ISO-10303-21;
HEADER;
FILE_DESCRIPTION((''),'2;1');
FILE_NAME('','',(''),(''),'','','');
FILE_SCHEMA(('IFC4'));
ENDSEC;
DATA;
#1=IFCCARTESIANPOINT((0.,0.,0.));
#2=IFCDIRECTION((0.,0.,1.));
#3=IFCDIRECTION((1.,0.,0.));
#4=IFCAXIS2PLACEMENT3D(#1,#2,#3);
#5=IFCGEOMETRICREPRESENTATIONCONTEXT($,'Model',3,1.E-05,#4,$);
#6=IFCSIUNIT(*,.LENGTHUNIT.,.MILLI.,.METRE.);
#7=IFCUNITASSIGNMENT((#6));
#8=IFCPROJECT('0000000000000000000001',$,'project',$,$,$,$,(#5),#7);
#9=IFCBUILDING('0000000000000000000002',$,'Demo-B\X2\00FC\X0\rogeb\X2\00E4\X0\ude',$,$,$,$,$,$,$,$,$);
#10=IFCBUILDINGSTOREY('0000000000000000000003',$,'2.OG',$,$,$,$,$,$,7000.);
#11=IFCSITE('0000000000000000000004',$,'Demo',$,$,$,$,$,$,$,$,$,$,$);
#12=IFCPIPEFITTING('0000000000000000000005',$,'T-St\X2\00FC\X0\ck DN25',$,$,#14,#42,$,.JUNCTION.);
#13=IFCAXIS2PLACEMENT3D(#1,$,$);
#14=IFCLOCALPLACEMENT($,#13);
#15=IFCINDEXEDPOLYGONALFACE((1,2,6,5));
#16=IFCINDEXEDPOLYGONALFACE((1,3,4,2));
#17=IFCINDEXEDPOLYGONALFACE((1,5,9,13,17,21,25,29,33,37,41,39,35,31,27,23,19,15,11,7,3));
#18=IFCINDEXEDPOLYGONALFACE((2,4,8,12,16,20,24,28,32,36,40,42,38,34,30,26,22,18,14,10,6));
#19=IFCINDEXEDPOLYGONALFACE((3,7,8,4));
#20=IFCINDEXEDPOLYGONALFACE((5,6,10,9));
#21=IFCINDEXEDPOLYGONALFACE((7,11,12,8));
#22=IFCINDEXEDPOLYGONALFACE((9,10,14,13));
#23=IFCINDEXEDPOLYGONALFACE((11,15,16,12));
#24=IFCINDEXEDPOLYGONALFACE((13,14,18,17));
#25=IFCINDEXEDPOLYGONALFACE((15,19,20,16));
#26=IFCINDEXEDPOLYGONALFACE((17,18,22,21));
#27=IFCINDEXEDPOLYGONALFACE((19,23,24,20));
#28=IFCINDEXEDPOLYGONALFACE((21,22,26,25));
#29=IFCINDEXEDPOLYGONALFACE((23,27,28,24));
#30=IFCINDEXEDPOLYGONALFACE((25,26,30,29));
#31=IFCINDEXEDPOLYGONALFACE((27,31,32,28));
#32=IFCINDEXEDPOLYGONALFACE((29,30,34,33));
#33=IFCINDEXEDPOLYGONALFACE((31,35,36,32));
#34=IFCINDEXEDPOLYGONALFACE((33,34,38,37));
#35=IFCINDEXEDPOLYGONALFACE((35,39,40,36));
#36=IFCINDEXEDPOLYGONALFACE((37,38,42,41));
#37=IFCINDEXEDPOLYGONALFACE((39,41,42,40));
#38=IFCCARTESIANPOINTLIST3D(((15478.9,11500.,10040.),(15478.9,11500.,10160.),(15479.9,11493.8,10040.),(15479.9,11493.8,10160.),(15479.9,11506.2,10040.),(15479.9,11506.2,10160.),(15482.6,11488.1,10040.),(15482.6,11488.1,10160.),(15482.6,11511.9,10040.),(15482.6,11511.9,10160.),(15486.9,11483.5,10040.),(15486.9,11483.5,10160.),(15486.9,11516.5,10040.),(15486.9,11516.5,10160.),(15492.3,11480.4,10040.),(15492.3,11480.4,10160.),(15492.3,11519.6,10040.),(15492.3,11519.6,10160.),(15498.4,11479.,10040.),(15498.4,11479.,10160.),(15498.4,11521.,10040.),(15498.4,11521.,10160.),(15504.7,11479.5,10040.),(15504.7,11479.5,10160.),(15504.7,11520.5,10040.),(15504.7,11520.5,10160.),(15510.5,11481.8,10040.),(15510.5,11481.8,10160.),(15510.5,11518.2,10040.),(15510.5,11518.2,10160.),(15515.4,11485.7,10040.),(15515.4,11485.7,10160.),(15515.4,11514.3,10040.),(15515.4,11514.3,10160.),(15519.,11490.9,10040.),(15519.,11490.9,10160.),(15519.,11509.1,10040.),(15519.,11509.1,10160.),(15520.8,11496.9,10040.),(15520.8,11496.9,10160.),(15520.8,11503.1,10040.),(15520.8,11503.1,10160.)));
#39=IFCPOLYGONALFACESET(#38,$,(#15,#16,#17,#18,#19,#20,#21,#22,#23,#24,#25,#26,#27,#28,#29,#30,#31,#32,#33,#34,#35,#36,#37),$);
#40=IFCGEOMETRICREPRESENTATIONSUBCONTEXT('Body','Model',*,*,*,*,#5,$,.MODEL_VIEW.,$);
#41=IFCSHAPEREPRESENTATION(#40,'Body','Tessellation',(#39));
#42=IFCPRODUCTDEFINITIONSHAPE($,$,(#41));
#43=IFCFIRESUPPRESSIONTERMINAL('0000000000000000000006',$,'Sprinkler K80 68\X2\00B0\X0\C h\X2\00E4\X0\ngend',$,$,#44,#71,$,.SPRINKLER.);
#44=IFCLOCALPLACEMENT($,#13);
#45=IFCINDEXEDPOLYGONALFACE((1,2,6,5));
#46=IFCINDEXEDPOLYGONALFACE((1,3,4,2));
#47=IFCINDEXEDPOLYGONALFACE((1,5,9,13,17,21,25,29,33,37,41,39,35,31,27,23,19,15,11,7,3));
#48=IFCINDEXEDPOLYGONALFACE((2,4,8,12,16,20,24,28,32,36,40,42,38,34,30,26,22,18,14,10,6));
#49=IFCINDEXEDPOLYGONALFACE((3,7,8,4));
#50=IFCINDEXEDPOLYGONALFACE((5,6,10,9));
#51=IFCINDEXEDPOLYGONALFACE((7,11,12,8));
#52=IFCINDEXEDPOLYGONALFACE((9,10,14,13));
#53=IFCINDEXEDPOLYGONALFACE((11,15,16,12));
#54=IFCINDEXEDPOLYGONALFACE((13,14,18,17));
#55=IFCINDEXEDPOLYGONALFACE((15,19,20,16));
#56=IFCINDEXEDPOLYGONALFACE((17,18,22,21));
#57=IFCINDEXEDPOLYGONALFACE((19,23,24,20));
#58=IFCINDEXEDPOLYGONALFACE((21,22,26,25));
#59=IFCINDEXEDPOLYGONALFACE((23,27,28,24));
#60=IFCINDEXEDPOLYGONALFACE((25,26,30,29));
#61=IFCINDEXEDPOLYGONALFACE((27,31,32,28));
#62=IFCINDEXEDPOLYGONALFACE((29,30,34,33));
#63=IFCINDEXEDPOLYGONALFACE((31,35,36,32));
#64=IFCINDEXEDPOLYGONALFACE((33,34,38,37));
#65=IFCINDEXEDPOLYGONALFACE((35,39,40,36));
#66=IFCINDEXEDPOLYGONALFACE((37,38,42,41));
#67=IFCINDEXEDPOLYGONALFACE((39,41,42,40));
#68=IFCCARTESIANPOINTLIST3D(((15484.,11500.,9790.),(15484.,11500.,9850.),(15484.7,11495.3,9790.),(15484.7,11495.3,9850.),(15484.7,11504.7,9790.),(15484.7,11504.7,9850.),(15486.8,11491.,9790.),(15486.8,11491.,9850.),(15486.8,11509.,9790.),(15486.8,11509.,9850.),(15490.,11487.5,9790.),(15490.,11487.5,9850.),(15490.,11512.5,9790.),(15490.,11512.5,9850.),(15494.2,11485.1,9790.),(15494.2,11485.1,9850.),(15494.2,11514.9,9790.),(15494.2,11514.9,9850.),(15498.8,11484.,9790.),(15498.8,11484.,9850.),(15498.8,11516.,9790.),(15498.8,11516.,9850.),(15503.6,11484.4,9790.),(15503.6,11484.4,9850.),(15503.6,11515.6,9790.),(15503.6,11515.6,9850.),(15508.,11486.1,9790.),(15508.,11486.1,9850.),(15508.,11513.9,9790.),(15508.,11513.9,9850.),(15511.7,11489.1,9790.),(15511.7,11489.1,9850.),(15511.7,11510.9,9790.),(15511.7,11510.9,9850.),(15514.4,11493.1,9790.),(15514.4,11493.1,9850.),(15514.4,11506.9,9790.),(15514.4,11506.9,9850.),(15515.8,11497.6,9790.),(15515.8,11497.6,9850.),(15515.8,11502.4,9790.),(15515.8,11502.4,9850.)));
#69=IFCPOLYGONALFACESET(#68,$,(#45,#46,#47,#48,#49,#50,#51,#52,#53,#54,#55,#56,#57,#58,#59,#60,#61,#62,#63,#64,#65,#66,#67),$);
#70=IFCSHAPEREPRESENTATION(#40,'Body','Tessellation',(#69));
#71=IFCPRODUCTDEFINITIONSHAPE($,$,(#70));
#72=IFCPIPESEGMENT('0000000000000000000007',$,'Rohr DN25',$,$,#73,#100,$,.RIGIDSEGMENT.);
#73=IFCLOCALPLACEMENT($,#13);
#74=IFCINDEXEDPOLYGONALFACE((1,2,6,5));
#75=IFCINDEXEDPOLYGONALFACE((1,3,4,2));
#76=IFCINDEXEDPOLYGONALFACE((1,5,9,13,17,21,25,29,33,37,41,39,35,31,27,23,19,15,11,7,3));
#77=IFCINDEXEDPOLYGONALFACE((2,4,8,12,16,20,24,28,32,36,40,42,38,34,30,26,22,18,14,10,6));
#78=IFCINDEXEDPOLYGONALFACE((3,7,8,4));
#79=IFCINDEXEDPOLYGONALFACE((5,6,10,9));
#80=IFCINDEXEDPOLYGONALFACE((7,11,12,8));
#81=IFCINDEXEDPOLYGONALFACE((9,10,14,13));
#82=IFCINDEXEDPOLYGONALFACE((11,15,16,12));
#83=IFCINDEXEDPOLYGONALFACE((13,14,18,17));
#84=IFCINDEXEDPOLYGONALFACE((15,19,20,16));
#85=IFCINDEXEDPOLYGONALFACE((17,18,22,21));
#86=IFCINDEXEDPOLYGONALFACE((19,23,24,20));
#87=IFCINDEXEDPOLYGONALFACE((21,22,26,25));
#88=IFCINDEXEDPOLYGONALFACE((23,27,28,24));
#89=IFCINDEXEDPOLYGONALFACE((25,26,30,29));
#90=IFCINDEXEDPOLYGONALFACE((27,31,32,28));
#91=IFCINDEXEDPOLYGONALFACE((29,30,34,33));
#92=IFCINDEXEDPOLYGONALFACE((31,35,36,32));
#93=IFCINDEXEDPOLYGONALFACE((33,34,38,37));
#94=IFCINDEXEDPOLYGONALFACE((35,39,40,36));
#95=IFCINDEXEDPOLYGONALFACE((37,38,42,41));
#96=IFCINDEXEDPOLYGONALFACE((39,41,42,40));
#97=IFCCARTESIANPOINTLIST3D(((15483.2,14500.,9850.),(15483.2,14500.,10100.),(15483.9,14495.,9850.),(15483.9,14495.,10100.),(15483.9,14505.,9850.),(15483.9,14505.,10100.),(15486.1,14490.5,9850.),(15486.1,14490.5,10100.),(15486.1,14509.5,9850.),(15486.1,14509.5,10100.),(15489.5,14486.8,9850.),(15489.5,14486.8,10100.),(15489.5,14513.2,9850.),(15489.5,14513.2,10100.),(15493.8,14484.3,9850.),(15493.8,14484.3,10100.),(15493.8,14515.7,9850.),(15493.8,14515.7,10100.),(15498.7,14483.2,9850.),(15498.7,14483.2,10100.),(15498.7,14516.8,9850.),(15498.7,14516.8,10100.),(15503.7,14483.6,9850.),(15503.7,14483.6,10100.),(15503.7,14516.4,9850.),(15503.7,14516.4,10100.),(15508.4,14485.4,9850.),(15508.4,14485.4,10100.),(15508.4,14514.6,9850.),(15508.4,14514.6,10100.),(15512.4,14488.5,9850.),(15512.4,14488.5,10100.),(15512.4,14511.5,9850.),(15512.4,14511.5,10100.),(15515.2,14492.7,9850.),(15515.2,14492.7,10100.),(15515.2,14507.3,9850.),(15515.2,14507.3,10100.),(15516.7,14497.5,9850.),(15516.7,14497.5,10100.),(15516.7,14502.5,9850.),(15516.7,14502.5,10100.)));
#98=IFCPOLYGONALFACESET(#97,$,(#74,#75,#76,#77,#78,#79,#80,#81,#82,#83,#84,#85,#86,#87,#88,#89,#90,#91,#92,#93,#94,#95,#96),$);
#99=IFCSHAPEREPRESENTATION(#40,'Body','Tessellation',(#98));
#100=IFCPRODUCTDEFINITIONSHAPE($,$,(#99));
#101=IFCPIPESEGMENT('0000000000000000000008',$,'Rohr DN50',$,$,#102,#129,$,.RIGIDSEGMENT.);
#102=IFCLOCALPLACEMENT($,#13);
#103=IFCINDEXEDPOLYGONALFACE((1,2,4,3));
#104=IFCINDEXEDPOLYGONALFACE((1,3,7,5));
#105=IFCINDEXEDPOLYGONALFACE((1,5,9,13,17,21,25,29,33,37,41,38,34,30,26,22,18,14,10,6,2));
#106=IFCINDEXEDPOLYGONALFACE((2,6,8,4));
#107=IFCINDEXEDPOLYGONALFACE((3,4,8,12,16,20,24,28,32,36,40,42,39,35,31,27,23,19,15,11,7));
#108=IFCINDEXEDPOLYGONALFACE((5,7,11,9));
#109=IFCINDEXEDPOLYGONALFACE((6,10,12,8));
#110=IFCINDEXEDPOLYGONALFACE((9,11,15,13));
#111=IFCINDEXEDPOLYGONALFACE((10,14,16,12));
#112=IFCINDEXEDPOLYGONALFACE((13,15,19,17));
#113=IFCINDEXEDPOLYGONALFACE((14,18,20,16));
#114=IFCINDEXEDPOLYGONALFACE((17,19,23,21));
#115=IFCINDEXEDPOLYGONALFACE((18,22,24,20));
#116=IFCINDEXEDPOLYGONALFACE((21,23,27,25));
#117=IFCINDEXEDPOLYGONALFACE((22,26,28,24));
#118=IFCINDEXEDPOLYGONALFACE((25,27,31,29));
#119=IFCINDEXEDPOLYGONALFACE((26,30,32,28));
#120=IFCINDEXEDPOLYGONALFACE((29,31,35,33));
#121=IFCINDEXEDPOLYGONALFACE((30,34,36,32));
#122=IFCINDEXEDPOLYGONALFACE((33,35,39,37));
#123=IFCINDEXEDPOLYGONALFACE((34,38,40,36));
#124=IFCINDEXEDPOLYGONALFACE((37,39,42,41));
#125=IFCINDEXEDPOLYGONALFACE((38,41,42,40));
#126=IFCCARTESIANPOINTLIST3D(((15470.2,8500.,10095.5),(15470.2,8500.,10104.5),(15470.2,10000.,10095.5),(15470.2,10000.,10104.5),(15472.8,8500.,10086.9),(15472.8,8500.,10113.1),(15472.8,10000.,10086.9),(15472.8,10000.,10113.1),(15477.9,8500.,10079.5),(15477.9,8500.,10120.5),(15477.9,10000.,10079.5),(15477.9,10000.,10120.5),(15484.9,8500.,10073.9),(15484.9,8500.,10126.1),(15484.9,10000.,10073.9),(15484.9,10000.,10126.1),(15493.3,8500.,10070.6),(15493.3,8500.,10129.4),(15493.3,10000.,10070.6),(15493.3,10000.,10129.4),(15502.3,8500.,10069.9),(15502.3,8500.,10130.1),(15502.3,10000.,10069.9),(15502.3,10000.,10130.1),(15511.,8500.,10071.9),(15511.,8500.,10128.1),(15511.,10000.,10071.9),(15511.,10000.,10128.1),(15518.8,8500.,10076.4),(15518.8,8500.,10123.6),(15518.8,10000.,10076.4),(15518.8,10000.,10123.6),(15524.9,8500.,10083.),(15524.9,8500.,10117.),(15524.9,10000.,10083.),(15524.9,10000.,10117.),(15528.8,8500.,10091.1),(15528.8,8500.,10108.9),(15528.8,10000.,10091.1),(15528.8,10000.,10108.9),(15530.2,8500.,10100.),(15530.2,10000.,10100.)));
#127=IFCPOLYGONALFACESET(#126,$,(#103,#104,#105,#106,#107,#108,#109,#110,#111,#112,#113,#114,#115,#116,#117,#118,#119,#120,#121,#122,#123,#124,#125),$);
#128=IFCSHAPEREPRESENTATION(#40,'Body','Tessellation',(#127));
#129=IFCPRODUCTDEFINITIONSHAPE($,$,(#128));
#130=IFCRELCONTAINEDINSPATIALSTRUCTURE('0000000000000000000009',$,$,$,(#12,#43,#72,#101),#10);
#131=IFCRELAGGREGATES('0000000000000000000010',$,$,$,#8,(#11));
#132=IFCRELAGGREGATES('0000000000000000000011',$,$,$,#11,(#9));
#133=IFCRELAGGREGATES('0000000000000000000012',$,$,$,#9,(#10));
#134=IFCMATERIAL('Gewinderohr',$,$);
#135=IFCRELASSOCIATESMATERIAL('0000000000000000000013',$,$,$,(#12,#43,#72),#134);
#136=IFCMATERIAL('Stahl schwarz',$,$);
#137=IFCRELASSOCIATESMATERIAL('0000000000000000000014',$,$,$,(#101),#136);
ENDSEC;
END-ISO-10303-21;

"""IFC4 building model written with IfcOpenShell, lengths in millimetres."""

from ifc_helpers import new_model, si_unit, frame, origin_with_axes, place, context, subcontext, project, spatial, circle, extrude, material, element, save


model = new_model("IFC4")

# Units and contexts
model_context = context("Model", 3, precision=1e-05, world=origin_with_axes())
body_context = subcontext(model_context, "Body", "Model", "MODEL_VIEW")
ifc_project = project(units=[si_unit("LENGTHUNIT", "METRE", prefix="MILLI")], contexts=[model_context])

# Site, building, storey
site = spatial("IfcSite", under=ifc_project, Name="Demo")
building = spatial("IfcBuilding", under=site, Name="Demo-Bürogebäude")
storey = spatial("IfcBuildingStorey", under=building, Name="2.OG", Elevation=7000.0)

# Shared definitions
ifc_material_1 = material(Name="Stahl schwarz")

# Shared definitions
ifc_material_2 = material(Name="Gewinderohr")

# Pipe fitting
pipe_fitting_1_placement = place(None, frame((15500.0, 11500.0, 10160.0), z_axis=(0.0, 0.0, -1.0), x_axis=(-1.0, 0.0, 0.0)))
element("IfcPipeFitting", 1, at=pipe_fitting_1_placement, inside=storey, material=ifc_material_2, Name="T-Stück DN25", PredefinedType="JUNCTION", context=body_context, shape_type="SweptSolid", body=[
    extrude(circle(Radius=21.1), origin_with_axes(), (0.0, 0.0, 1.0), 120.0),
])

# Fire suppression terminal
fire_suppression_terminal_1_placement = place(None, frame((15500.0, 11500.0, 9850.0), z_axis=(0.0, 0.0, -1.0), x_axis=(-1.0, 0.0, 0.0)))
element("IfcFireSuppressionTerminal", 2, at=fire_suppression_terminal_1_placement, inside=storey, material=ifc_material_2, Name="Sprinkler K80 68°C hängend", PredefinedType="SPRINKLER", context=body_context, shape_type="SweptSolid", body=[
    extrude(circle(Radius=16.0), origin_with_axes(), (0.0, 0.0, 1.0), 60.0),
])

# Pipe segments
pipe_segment_1_placement = place(None, frame((15500.0, 14500.0, 10100.0), z_axis=(0.0, 0.0, -1.0), x_axis=(-1.0, 0.0, 0.0)))
element("IfcPipeSegment", 3, at=pipe_segment_1_placement, inside=storey, material=ifc_material_2, Name="Rohr DN25", PredefinedType="RIGIDSEGMENT", context=body_context, shape_type="SweptSolid", body=[
    extrude(circle(Radius=16.9), origin_with_axes(), (0.0, 0.0, 1.0), 250.0),
])
pipe_segment_2_placement = place(None, frame((15500.0, 10000.0, 10100.0), z_axis=(0.0, -1.0, 0.0), x_axis=(1.0, 0.0, 0.0)))
element("IfcPipeSegment", 4, at=pipe_segment_2_placement, inside=storey, material=ifc_material_1, Name="Rohr DN50", PredefinedType="RIGIDSEGMENT", context=body_context, shape_type="SweptSolid", body=[
    extrude(circle(Radius=30.1), origin_with_axes(), (0.0, 0.0, 1.0), 1500.0),
])

save(model, "model.ifc")
